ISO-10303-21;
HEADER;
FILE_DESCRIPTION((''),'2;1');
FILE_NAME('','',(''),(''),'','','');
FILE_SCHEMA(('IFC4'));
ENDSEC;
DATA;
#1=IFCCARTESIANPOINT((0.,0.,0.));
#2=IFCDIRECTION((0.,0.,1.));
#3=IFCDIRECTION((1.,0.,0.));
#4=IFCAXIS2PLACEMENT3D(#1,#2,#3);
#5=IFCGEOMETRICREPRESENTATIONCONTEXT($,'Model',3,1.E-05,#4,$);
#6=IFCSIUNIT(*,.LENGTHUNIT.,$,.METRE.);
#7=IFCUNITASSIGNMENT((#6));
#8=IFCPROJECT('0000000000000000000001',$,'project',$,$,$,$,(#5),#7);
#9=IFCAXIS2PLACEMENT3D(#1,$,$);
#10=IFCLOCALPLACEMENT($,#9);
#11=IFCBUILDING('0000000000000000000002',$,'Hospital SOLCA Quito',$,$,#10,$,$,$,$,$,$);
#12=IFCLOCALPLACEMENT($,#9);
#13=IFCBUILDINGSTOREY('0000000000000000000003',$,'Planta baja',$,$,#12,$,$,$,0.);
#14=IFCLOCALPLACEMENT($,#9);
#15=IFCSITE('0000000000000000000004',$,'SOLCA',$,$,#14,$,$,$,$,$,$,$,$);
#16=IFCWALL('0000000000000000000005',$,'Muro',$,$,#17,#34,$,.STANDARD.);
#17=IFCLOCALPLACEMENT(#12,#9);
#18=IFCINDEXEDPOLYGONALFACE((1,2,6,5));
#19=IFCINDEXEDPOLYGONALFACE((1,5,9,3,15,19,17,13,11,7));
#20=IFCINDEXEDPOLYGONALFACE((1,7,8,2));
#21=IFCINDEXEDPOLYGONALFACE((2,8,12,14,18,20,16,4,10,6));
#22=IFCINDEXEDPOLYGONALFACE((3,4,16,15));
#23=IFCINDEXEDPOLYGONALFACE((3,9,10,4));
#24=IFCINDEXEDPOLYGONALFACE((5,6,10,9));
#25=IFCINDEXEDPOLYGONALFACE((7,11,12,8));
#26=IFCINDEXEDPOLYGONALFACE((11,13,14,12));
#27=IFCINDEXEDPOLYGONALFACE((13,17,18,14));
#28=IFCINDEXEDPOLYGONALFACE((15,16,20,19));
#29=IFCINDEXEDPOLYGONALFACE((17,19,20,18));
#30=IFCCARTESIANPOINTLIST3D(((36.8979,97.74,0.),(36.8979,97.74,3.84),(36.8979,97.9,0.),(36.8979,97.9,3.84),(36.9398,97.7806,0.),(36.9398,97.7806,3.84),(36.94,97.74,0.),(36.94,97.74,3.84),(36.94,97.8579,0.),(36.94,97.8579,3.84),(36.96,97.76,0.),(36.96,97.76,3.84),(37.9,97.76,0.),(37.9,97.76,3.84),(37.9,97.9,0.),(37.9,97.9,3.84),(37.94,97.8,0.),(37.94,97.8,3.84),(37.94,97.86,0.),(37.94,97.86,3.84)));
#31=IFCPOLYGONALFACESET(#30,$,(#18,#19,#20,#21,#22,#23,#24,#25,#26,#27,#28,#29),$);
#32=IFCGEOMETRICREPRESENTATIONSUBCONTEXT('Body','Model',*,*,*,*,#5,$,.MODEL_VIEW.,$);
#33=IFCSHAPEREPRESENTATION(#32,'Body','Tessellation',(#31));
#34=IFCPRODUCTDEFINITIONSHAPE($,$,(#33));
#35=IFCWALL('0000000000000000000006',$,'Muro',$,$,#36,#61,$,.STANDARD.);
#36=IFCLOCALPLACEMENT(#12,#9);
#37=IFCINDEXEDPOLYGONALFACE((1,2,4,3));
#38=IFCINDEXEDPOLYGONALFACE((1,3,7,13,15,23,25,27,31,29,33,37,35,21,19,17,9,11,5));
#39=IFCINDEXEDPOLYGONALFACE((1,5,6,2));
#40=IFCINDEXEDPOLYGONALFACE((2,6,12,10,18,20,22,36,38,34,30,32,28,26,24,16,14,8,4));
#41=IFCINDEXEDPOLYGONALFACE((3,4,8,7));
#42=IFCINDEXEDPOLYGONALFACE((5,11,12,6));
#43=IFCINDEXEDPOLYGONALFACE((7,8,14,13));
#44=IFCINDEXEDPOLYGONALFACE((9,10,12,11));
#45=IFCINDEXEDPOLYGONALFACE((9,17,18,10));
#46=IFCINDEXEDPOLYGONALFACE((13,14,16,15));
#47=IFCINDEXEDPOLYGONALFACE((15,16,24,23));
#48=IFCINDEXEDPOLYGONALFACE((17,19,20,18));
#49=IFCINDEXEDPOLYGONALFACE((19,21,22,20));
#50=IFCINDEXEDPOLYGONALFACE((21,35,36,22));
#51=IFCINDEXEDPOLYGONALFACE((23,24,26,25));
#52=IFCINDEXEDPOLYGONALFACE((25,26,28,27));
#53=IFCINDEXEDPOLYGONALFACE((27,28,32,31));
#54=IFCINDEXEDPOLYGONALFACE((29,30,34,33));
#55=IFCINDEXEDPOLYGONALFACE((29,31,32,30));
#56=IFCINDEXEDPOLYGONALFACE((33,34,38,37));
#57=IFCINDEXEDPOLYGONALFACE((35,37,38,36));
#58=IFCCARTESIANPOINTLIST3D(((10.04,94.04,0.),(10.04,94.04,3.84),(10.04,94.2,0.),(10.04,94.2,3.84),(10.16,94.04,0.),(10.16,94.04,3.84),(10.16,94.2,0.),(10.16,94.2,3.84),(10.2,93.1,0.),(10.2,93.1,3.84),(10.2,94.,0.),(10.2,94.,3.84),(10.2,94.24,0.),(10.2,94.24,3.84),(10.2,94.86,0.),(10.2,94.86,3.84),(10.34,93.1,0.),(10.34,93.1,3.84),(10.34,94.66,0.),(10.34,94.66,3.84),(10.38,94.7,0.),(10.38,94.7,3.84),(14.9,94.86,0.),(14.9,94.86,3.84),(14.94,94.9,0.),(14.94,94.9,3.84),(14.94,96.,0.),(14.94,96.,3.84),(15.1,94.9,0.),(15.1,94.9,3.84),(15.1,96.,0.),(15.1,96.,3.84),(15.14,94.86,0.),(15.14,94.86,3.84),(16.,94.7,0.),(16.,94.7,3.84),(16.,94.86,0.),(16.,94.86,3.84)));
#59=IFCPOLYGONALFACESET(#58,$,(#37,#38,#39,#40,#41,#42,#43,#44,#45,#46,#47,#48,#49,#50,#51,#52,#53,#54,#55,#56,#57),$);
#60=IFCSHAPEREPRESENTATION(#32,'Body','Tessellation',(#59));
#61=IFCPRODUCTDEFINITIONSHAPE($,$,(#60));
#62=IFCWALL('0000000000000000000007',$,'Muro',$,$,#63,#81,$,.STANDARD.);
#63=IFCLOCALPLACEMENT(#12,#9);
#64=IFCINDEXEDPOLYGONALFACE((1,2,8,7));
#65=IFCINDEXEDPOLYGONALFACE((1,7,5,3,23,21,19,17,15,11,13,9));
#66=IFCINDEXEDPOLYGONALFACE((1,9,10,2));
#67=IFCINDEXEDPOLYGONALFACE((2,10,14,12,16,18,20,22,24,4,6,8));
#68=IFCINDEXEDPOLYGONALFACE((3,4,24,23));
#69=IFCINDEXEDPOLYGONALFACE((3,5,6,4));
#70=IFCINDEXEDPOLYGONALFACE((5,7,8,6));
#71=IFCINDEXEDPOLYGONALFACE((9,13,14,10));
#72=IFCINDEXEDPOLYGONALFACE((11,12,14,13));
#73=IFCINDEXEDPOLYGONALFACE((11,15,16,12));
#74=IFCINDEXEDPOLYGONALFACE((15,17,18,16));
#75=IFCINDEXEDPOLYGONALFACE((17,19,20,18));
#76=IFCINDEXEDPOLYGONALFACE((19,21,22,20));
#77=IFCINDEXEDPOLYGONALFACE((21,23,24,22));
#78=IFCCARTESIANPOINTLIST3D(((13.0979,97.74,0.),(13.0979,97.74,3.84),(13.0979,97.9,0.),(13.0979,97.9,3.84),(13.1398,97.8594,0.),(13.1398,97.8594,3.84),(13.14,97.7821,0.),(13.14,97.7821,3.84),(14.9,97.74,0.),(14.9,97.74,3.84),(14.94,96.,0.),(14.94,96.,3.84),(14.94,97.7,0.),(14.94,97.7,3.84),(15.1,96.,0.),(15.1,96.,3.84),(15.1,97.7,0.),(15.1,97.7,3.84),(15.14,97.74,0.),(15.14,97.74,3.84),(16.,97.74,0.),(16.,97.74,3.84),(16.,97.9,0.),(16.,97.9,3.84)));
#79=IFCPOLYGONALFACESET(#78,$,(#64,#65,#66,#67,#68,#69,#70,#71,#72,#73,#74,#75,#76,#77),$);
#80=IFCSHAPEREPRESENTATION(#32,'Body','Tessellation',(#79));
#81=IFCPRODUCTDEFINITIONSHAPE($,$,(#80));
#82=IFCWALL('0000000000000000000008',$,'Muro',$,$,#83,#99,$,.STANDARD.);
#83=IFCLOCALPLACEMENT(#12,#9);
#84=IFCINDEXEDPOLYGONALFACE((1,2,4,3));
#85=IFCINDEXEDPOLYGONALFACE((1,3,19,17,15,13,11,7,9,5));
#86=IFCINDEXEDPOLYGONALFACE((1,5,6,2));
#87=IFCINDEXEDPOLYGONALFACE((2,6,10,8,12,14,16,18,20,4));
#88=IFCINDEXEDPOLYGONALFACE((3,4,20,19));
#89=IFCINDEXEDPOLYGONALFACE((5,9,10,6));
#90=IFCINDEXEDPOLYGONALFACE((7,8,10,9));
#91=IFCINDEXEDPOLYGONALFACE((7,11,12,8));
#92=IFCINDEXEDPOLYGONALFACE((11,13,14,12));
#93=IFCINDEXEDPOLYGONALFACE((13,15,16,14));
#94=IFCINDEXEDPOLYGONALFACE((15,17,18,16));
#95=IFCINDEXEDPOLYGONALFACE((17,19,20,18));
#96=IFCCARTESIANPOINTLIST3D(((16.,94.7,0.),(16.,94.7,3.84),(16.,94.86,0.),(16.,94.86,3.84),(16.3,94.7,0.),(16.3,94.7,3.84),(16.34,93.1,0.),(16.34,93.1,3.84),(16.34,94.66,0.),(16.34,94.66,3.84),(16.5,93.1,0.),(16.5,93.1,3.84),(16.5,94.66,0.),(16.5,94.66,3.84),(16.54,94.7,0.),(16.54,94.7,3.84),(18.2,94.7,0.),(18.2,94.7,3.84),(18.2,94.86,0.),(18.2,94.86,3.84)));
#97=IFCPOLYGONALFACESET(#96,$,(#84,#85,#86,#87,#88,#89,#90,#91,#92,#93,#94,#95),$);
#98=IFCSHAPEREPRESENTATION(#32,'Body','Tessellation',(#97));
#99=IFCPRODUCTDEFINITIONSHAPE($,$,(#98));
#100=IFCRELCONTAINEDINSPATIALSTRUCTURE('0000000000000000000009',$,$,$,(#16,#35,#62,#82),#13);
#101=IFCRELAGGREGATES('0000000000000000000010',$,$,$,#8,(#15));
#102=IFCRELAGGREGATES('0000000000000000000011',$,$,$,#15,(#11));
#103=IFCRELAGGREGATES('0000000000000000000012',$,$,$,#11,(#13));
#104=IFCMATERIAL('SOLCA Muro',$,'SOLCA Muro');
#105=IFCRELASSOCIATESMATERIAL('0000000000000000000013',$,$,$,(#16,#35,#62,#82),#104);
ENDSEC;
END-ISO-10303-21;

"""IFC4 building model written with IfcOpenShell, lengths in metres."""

from ifc_helpers import new_model, si_unit, origin, origin_with_axes, place, context, subcontext, project, spatial, polyline, outline, extrude, material, element, save


model = new_model("IFC4")

# Units and contexts
model_context = context("Model", 3, precision=1e-05, world=origin_with_axes())
body_context = subcontext(model_context, "Body", "Model", "MODEL_VIEW")
ifc_project = project(units=[si_unit("LENGTHUNIT", "METRE")], contexts=[model_context])

# Site, building, storey
site_placement = place(None, origin())
site = spatial("IfcSite", under=ifc_project, at=site_placement, Name="SOLCA")
building_placement = place(None, origin())
building = spatial("IfcBuilding", under=site, at=building_placement, Name="Hospital SOLCA Quito")
storey_placement = place(None, origin())
storey = spatial("IfcBuildingStorey", under=building, at=storey_placement, Name="Planta baja", Elevation=0.0)

# Walls
ifc_material = material(Name="SOLCA Muro", Category="SOLCA Muro")
wall_1_placement = place(storey_placement, origin_with_axes())
element("IfcWall", 1, at=wall_1_placement, inside=storey, material=ifc_material, Name="Muro", PredefinedType="STANDARD", context=body_context, shape_type="SweptSolid", body=[
    extrude(outline(polyline([(36.8979, 97.74), (36.9398, 97.7806), (36.94, 97.8579), (36.8979, 97.9), (37.9, 97.9), (37.94, 97.86), (37.94, 97.8), (37.9, 97.76), (36.96, 97.76), (36.94, 97.74), (36.8979, 97.74)])), origin_with_axes(), (0.0, 0.0, 1.0), 3.84),
])
wall_2_placement = place(storey_placement, origin_with_axes())
element("IfcWall", 2, at=wall_2_placement, inside=storey, material=ifc_material, Name="Muro", PredefinedType="STANDARD", context=body_context, shape_type="SweptSolid", body=[
    extrude(outline(polyline([(10.38, 94.7), (10.34, 94.66), (10.34, 93.1), (10.2, 93.1), (10.2, 94.0), (10.16, 94.04), (10.04, 94.04), (10.04, 94.2), (10.16, 94.2), (10.2, 94.24), (10.2, 94.86), (14.9, 94.86), (14.94, 94.9), (14.94, 96.0), (15.1, 96.0), (15.1, 94.9), (15.14, 94.86), (16.0, 94.86), (16.0, 94.7), (10.38, 94.7)])), origin_with_axes(), (0.0, 0.0, 1.0), 3.84),
])
wall_3_placement = place(storey_placement, origin_with_axes())
element("IfcWall", 3, at=wall_3_placement, inside=storey, material=ifc_material, Name="Muro", PredefinedType="STANDARD", context=body_context, shape_type="SweptSolid", body=[
    extrude(outline(polyline([(14.94, 97.7), (14.9, 97.74), (13.0979, 97.74), (13.14, 97.7821), (13.1398, 97.8594), (13.0979, 97.9), (16.0, 97.9), (16.0, 97.74), (15.14, 97.74), (15.1, 97.7), (15.1, 96.0), (14.94, 96.0), (14.94, 97.7)])), origin_with_axes(), (0.0, 0.0, 1.0), 3.84),
])
wall_4_placement = place(storey_placement, origin_with_axes())
element("IfcWall", 4, at=wall_4_placement, inside=storey, material=ifc_material, Name="Muro", PredefinedType="STANDARD", context=body_context, shape_type="SweptSolid", body=[
    extrude(outline(polyline([(16.34, 94.66), (16.3, 94.7), (16.0, 94.7), (16.0, 94.86), (18.2, 94.86), (18.2, 94.7), (16.54, 94.7), (16.5, 94.66), (16.5, 93.1), (16.34, 93.1), (16.34, 94.66)])), origin_with_axes(), (0.0, 0.0, 1.0), 3.84),
])

save(model, "model.ifc")
